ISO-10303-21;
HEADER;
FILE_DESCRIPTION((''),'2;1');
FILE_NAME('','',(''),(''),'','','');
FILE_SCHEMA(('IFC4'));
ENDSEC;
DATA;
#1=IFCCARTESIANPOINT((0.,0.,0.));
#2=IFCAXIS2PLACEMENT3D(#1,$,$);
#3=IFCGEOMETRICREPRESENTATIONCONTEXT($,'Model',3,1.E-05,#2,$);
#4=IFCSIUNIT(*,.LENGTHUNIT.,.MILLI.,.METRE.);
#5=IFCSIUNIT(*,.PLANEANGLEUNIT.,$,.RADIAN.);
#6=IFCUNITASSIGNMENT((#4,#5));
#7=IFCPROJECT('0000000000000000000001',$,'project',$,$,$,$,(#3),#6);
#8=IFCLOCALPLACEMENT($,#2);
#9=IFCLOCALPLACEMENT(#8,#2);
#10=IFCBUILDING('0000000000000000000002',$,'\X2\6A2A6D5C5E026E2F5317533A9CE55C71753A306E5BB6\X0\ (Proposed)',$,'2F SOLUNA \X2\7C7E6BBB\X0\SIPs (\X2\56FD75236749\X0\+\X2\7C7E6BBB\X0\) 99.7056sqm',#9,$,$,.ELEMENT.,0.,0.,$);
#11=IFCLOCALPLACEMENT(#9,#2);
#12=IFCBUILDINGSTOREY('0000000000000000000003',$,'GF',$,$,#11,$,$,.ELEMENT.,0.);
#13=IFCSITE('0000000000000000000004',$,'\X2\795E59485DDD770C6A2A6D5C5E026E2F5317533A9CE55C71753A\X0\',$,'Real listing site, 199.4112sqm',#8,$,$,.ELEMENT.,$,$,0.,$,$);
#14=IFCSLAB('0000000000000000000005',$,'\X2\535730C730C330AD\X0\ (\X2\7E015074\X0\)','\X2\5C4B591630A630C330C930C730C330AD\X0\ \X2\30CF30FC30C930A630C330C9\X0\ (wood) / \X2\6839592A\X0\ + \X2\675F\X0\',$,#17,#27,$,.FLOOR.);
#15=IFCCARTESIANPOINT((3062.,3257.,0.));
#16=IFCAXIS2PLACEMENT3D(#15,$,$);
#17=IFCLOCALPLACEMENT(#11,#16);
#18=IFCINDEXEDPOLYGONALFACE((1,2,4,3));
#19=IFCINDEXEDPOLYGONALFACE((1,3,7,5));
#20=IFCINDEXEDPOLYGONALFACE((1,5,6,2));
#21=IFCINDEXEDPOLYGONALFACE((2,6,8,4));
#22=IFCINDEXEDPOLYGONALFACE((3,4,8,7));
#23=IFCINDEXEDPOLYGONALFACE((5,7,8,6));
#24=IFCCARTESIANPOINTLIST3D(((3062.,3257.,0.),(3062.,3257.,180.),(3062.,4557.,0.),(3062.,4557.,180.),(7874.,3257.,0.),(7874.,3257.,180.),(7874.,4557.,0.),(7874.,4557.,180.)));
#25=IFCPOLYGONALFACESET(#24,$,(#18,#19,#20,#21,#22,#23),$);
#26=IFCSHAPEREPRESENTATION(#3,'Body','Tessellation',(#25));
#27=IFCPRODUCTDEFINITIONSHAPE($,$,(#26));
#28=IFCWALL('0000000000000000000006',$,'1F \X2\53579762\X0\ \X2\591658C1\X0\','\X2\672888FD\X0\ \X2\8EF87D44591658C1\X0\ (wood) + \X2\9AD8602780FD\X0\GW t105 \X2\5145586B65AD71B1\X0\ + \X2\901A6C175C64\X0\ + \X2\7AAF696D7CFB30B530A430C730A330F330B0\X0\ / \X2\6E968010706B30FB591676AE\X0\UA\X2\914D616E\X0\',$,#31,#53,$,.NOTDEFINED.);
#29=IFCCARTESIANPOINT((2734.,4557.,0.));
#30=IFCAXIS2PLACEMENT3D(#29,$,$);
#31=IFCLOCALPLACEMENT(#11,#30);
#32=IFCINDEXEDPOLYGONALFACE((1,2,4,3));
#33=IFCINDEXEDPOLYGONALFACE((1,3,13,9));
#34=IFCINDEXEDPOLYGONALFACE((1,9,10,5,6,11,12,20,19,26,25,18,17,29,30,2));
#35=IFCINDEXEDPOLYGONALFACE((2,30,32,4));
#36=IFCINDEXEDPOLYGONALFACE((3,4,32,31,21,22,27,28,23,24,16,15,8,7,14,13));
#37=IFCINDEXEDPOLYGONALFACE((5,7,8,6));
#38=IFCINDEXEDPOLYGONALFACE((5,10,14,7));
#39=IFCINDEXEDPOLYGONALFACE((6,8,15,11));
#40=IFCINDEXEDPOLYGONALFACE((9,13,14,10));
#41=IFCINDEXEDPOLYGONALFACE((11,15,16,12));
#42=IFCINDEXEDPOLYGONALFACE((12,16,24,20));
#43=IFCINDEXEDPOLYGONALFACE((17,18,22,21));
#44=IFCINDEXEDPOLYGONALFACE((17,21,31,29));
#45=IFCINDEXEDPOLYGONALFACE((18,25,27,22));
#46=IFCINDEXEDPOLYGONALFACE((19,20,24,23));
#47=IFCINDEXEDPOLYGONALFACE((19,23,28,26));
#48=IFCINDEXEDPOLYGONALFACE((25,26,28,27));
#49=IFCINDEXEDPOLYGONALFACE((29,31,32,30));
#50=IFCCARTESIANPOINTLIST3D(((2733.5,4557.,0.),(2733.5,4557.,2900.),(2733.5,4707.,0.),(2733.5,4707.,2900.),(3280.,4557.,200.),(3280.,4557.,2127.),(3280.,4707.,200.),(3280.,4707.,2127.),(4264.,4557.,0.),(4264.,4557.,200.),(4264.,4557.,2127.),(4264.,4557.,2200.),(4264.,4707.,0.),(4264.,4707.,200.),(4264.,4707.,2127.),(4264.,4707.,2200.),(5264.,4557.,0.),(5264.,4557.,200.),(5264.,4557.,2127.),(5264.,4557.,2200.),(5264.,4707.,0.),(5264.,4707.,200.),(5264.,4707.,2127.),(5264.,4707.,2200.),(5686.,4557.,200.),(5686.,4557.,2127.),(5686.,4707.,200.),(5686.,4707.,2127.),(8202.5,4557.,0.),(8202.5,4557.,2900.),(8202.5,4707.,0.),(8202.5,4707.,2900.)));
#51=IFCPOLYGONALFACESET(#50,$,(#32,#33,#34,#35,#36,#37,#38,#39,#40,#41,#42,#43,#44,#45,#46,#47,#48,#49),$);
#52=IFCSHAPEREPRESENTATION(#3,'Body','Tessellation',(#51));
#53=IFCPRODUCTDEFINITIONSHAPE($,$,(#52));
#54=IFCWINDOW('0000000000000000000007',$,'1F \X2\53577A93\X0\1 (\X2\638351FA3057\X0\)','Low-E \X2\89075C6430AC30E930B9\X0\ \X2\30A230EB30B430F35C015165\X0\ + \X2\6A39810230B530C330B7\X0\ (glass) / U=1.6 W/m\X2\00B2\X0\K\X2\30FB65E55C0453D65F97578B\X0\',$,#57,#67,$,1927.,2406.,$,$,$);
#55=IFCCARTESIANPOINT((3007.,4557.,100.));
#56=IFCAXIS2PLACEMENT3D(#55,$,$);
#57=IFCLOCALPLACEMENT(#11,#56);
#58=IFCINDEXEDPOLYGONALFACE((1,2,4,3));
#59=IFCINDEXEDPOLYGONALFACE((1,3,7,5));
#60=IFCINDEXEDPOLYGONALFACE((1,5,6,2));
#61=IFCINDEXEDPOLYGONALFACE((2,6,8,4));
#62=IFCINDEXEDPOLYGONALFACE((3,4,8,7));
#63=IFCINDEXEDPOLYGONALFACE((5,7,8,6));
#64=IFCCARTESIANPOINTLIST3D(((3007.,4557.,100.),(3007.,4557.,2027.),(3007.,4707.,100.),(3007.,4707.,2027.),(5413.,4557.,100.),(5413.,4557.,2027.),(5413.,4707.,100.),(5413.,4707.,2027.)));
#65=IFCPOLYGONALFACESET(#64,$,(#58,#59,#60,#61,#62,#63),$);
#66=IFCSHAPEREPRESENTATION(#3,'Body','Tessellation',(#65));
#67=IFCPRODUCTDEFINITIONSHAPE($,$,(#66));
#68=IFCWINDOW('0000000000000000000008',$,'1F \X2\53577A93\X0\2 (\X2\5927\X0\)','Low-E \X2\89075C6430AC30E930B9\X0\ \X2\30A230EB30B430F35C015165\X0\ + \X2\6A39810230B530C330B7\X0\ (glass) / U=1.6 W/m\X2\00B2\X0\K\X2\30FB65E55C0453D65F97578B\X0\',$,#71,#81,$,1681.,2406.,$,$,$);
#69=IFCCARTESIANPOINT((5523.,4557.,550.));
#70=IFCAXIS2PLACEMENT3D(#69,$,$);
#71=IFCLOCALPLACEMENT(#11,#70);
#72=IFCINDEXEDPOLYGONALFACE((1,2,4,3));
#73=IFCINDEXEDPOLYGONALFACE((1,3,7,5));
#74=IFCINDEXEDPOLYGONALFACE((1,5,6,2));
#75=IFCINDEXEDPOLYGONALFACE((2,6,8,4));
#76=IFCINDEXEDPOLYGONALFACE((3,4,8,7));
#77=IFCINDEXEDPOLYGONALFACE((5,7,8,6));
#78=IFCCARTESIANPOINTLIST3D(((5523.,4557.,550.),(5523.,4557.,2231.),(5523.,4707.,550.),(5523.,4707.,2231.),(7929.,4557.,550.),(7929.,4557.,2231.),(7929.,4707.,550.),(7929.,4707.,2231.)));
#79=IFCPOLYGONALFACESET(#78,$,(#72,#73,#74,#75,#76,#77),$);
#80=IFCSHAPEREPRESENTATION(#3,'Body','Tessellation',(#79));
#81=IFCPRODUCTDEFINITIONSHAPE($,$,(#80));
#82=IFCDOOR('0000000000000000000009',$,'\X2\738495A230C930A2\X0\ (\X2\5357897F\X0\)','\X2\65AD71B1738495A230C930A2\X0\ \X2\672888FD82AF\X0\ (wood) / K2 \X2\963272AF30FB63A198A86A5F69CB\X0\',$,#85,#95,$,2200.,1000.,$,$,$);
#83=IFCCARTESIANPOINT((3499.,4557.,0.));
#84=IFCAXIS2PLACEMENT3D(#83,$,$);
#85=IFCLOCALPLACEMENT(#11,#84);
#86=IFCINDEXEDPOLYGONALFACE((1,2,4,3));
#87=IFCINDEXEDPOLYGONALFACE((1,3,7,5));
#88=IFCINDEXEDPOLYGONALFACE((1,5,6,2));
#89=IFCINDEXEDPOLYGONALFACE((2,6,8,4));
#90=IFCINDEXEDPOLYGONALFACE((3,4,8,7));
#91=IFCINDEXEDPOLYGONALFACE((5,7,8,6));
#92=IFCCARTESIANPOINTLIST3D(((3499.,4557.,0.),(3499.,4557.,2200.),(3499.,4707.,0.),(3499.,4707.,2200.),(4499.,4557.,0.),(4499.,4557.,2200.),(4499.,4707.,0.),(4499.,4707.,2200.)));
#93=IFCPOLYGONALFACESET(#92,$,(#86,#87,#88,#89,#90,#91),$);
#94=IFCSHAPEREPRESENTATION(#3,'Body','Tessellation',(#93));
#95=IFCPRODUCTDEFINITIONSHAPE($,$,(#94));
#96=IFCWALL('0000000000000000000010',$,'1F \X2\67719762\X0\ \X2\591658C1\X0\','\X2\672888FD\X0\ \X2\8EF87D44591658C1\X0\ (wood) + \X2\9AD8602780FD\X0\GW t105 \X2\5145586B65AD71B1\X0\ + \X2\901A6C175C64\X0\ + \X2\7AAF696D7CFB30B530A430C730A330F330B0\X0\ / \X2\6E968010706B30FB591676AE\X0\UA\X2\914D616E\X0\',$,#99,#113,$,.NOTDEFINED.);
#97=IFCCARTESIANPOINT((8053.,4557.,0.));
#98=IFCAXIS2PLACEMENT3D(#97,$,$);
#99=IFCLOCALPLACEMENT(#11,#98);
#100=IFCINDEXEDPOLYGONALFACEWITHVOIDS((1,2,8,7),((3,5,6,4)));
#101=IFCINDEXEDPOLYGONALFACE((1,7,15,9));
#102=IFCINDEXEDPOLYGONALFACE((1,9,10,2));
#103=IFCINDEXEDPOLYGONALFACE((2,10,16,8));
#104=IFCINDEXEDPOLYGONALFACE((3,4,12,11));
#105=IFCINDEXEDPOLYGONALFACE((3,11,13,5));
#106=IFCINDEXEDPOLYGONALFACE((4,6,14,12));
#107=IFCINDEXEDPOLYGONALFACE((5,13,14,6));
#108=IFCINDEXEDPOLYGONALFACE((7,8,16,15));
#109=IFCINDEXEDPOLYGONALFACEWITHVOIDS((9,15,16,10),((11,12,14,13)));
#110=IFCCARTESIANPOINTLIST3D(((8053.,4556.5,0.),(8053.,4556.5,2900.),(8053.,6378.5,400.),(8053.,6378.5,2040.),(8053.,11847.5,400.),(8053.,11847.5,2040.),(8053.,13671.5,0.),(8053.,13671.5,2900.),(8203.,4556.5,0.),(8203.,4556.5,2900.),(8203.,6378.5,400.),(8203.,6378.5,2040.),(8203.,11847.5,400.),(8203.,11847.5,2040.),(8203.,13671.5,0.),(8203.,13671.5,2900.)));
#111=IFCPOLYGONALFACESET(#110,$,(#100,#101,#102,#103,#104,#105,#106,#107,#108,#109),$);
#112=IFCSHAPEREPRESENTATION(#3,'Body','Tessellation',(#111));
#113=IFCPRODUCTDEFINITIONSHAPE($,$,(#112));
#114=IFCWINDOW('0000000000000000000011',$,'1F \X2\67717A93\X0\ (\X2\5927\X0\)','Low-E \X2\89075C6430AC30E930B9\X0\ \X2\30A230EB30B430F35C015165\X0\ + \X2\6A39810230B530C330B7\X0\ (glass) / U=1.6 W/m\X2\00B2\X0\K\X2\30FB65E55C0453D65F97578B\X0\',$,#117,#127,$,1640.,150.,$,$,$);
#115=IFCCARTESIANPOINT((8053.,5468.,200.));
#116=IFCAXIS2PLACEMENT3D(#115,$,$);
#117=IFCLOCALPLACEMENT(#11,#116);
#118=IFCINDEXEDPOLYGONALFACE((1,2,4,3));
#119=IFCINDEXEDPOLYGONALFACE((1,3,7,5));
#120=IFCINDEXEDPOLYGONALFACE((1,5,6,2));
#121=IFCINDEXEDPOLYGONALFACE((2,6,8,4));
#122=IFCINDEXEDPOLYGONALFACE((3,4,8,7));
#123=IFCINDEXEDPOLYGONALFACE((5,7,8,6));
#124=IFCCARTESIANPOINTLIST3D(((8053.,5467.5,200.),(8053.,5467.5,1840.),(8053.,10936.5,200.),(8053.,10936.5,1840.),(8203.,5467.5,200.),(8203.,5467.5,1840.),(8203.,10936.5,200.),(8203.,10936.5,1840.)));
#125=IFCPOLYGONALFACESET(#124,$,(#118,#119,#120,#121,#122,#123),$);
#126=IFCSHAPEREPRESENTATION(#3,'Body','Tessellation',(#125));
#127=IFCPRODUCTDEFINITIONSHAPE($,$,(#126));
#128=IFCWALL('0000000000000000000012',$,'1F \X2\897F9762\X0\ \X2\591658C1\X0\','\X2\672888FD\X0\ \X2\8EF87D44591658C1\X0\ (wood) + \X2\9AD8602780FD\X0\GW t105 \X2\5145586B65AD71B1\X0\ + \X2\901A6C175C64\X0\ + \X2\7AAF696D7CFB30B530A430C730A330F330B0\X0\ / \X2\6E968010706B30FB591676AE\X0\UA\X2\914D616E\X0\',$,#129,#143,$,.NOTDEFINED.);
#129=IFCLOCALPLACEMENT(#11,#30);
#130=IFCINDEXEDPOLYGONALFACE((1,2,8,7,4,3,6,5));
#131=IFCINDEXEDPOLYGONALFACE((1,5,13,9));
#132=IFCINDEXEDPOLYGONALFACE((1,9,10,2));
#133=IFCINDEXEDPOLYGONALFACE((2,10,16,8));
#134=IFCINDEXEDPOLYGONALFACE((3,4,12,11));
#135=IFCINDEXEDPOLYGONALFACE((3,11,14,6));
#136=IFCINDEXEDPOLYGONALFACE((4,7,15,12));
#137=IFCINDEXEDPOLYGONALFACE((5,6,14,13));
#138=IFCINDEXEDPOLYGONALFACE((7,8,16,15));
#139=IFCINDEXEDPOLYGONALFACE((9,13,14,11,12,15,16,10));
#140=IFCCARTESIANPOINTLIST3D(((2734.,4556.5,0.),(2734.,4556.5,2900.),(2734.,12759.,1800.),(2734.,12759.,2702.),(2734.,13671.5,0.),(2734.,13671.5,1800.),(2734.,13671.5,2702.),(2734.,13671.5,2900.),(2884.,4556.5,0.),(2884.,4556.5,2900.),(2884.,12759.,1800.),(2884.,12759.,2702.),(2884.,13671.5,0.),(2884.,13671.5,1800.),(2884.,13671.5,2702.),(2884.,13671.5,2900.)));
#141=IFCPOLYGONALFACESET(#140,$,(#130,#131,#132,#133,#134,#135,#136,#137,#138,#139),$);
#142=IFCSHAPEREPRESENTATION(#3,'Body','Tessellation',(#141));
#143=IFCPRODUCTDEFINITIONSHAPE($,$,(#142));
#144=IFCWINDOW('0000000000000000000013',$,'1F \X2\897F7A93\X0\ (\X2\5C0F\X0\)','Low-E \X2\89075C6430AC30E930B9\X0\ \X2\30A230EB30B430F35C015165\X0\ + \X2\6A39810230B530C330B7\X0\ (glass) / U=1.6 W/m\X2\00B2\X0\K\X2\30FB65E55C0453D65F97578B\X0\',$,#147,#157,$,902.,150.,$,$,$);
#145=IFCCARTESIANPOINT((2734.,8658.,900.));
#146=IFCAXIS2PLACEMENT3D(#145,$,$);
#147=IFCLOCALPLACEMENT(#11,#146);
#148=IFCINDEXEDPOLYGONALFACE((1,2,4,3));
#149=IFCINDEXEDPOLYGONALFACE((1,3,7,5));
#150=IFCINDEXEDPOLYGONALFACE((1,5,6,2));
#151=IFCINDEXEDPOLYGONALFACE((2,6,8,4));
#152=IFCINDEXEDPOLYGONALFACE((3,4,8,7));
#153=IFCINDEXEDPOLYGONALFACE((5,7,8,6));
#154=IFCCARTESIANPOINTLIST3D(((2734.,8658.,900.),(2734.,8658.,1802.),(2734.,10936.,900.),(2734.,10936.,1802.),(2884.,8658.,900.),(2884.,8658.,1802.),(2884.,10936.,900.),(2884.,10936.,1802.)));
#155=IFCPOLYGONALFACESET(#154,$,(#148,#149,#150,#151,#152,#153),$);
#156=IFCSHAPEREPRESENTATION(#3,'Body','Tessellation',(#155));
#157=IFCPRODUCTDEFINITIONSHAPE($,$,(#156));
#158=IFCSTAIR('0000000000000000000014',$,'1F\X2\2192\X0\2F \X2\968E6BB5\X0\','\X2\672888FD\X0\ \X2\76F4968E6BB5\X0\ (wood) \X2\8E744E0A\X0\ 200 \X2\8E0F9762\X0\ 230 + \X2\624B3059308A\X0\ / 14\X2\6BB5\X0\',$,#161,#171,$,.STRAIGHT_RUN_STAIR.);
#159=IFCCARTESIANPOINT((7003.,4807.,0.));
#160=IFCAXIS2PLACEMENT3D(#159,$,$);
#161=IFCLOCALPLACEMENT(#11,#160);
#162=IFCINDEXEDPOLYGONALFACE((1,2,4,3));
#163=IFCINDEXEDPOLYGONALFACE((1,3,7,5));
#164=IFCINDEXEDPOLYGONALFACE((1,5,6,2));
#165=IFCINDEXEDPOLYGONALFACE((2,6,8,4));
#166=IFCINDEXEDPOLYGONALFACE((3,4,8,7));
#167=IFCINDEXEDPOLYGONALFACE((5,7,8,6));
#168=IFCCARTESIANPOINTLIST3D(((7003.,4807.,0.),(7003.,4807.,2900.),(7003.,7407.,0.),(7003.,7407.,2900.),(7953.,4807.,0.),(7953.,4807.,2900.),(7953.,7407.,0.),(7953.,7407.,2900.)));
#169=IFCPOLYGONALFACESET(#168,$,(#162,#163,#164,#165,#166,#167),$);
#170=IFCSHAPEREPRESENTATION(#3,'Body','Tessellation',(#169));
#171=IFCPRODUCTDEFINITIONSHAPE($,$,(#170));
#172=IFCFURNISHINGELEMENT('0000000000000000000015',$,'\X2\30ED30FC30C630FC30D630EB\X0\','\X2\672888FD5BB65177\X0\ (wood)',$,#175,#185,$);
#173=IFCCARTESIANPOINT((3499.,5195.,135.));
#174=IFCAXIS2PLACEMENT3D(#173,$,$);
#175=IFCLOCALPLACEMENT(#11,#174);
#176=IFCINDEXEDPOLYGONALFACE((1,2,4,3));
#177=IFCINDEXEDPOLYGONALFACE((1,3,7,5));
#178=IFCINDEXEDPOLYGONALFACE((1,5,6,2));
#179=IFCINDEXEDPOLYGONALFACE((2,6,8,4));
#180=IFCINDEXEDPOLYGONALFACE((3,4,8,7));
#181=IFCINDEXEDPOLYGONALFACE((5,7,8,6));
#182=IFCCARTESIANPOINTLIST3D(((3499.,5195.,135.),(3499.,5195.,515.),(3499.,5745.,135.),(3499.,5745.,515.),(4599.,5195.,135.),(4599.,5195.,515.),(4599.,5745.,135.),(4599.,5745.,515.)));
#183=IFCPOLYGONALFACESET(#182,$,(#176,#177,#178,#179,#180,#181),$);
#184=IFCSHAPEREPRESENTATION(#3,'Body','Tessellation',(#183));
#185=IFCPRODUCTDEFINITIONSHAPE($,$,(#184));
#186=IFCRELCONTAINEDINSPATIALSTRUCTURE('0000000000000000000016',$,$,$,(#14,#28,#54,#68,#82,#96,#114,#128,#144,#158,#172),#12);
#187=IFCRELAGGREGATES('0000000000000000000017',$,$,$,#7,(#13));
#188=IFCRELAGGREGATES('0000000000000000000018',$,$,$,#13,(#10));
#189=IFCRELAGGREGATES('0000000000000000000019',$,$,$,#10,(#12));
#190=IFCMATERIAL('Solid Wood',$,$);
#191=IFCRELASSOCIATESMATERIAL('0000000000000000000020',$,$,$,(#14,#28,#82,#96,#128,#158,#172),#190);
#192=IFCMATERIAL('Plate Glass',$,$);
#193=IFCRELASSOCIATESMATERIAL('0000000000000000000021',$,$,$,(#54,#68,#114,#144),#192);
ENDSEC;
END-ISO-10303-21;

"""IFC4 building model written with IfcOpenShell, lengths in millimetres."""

from ifc_helpers import new_model, si_unit, frame, frame_2d, origin, place, context, project, spatial, rectangle, extrude, material, element, fill, save


model = new_model("IFC4")

# Units and contexts
model_context = context("Model", 3, precision=1e-05, world=origin())
ifc_project = project(units=[si_unit("LENGTHUNIT", "METRE", prefix="MILLI"), si_unit("PLANEANGLEUNIT", "RADIAN")], contexts=[model_context])

# Site, building, storey
site_placement = place(None, origin())
site = spatial("IfcSite", under=ifc_project, at=site_placement, Name="神奈川県横浜市港北区鳥山町", ObjectType="Real listing site, 199.4112sqm", CompositionType="ELEMENT", RefElevation=0.0)
building_placement = place(site_placement, origin())
building = spatial("IfcBuilding", under=site, at=building_placement, Name="横浜市港北区鳥山町の家 (Proposed)", ObjectType="2F SOLUNA 籾殻SIPs (国産杉+籾殻) 99.7056sqm", CompositionType="ELEMENT", ElevationOfRefHeight=0.0, ElevationOfTerrain=0.0)
storey_placement = place(building_placement, origin())
storey = spatial("IfcBuildingStorey", under=building, at=storey_placement, Name="GF", CompositionType="ELEMENT", Elevation=0.0)

# Slab
ifc_material_1 = material(Name="Solid Wood")
slab_1_placement = place(storey_placement, frame((3062.0, 3257.0, 0.0)))
element("IfcSlab", 1, at=slab_1_placement, inside=storey, material=ifc_material_1, Name="南デッキ (縁側)", Description="屋外ウッドデッキ ハードウッド (wood) / 根太 + 束", PredefinedType="FLOOR", context=model_context, shape_type="SweptSolid", body=[
    extrude(rectangle(XDim=4812.0, YDim=1300.0, at=frame_2d((2406.0, 650.0))), frame((3062.0, 3257.0, 0.0)), (0.0, 0.0, 1.0), 180.0),
])

# Wall, openings, windows, door
wall_1_placement = place(storey_placement, frame((2734.0, 4557.0, 0.0)))
wall_1 = element("IfcWall", 2, at=wall_1_placement, inside=storey, material=ifc_material_1, Name="1F 南面 外壁", Description="木製 軸組外壁 (wood) + 高性能GW t105 充填断熱 + 通気層 + 窯業系サイディング / 準耐火・外皮UA配慮", PredefinedType="NOTDEFINED", context=model_context, shape_type="SweptSolid", body=[
    extrude(rectangle(XDim=5469.0, YDim=150.0, at=frame_2d((2734.0, 75.0))), frame((2734.0, 4557.0, 0.0)), (0.0, 0.0, 1.0), 2900.0),
])
opening_1_placement = place(storey_placement, frame((3007.0, 4557.0, 100.0)))
opening_1 = element("IfcOpeningElement", 3, at=opening_1_placement, cuts=wall_1, PredefinedType="NOTDEFINED", context=model_context, shape_type="SweptSolid", body=[
    extrude(rectangle(XDim=2406.0, YDim=150.0, at=frame_2d((1203.0, 75.0))), frame((3007.0, 4557.0, 100.0)), (0.0, 0.0, 1.0), 1927.0),
])
opening_2_placement = place(storey_placement, frame((5523.0, 4557.0, 550.0)))
opening_2 = element("IfcOpeningElement", 4, at=opening_2_placement, cuts=wall_1, PredefinedType="NOTDEFINED", context=model_context, shape_type="SweptSolid", body=[
    extrude(rectangle(XDim=2406.0, YDim=150.0, at=frame_2d((1203.0, 75.0))), frame((5523.0, 4557.0, 550.0)), (0.0, 0.0, 1.0), 1681.0),
])
opening_3_placement = place(storey_placement, frame((3499.0, 4557.0, 0.0)))
opening_3 = element("IfcOpeningElement", 5, at=opening_3_placement, cuts=wall_1, PredefinedType="NOTDEFINED", context=model_context, shape_type="SweptSolid", body=[
    extrude(rectangle(XDim=1000.0, YDim=150.0, at=frame_2d((500.0, 75.0))), frame((3499.0, 4557.0, 0.0)), (0.0, 0.0, 1.0), 2200.0),
])
ifc_material_2 = material(Name="Plate Glass")
window_1_placement = place(storey_placement, frame((3007.0, 4557.0, 100.0)))
window_1 = element("IfcWindow", 6, at=window_1_placement, inside=storey, material=ifc_material_2, Name="1F 南窓1 (掃出し)", Description="Low-E 複層ガラス アルゴン封入 + 樹脂サッシ (glass) / U=1.6 W/m²K・日射取得型", OverallHeight=1927.0, OverallWidth=2406.0, context=model_context, shape_type="SweptSolid", body=[
    extrude(rectangle(XDim=2406.0, YDim=150.0, at=frame_2d((1203.0, 75.0))), frame((3007.0, 4557.0, 100.0)), (0.0, 0.0, 1.0), 1927.0),
])
fill(opening_1, window_1)
window_2_placement = place(storey_placement, frame((5523.0, 4557.0, 550.0)))
window_2 = element("IfcWindow", 7, at=window_2_placement, inside=storey, material=ifc_material_2, Name="1F 南窓2 (大)", Description="Low-E 複層ガラス アルゴン封入 + 樹脂サッシ (glass) / U=1.6 W/m²K・日射取得型", OverallHeight=1681.0, OverallWidth=2406.0, context=model_context, shape_type="SweptSolid", body=[
    extrude(rectangle(XDim=2406.0, YDim=150.0, at=frame_2d((1203.0, 75.0))), frame((5523.0, 4557.0, 550.0)), (0.0, 0.0, 1.0), 1681.0),
])
fill(opening_2, window_2)
door_placement = place(storey_placement, frame((3499.0, 4557.0, 0.0)))
door = element("IfcDoor", 8, at=door_placement, inside=storey, material=ifc_material_1, Name="玄関ドア (南西)", Description="断熱玄関ドア 木製芯 (wood) / K2 防犯・採風機構", OverallHeight=2200.0, OverallWidth=1000.0, context=model_context, shape_type="SweptSolid", body=[
    extrude(rectangle(XDim=1000.0, YDim=150.0, at=frame_2d((500.0, 75.0))), frame((3499.0, 4557.0, 0.0)), (0.0, 0.0, 1.0), 2200.0),
])
fill(opening_3, door)

# Walls, openings, windows
wall_2_placement = place(storey_placement, frame((8053.0, 4557.0, 0.0)))
wall_2 = element("IfcWall", 9, at=wall_2_placement, inside=storey, material=ifc_material_1, Name="1F 東面 外壁", Description="木製 軸組外壁 (wood) + 高性能GW t105 充填断熱 + 通気層 + 窯業系サイディング / 準耐火・外皮UA配慮", PredefinedType="NOTDEFINED", context=model_context, shape_type="SweptSolid", body=[
    extrude(rectangle(XDim=150.0, YDim=9115.0, at=frame_2d((75.0, 4557.0))), frame((8053.0, 4557.0, 0.0)), (0.0, 0.0, 1.0), 2900.0),
])
opening_4_placement = place(storey_placement, frame((8053.0, 5468.0, 200.0)))
opening_4 = element("IfcOpeningElement", 10, at=opening_4_placement, cuts=wall_2, PredefinedType="NOTDEFINED", context=model_context, shape_type="SweptSolid", body=[
    extrude(rectangle(XDim=150.0, YDim=5469.0, at=frame_2d((75.0, 2734.0))), frame((8053.0, 5468.0, 200.0)), (0.0, 0.0, 1.0), 1640.0),
])
window_3_placement = place(storey_placement, frame((8053.0, 5468.0, 200.0)))
window_3 = element("IfcWindow", 11, at=window_3_placement, inside=storey, material=ifc_material_2, Name="1F 東窓 (大)", Description="Low-E 複層ガラス アルゴン封入 + 樹脂サッシ (glass) / U=1.6 W/m²K・日射取得型", OverallHeight=1640.0, OverallWidth=150.0, context=model_context, shape_type="SweptSolid", body=[
    extrude(rectangle(XDim=150.0, YDim=5469.0, at=frame_2d((75.0, 2734.0))), frame((8053.0, 5468.0, 200.0)), (0.0, 0.0, 1.0), 1640.0),
])
fill(opening_4, window_3)
wall_3_placement = place(storey_placement, frame((2734.0, 4557.0, 0.0)))
wall_3 = element("IfcWall", 12, at=wall_3_placement, inside=storey, material=ifc_material_1, Name="1F 西面 外壁", Description="木製 軸組外壁 (wood) + 高性能GW t105 充填断熱 + 通気層 + 窯業系サイディング / 準耐火・外皮UA配慮", PredefinedType="NOTDEFINED", context=model_context, shape_type="SweptSolid", body=[
    extrude(rectangle(XDim=150.0, YDim=9115.0, at=frame_2d((75.0, 4557.0))), frame((2734.0, 4557.0, 0.0)), (0.0, 0.0, 1.0), 2900.0),
])
opening_5_placement = place(storey_placement, frame((2734.0, 8658.0, 900.0)))
opening_5 = element("IfcOpeningElement", 13, at=opening_5_placement, cuts=wall_3, PredefinedType="NOTDEFINED", context=model_context, shape_type="SweptSolid", body=[
    extrude(rectangle(XDim=150.0, YDim=2278.0, at=frame_2d((75.0, 1139.0))), frame((2734.0, 8658.0, 900.0)), (0.0, 0.0, 1.0), 902.0),
])
window_4_placement = place(storey_placement, frame((2734.0, 8658.0, 900.0)))
window_4 = element("IfcWindow", 14, at=window_4_placement, inside=storey, material=ifc_material_2, Name="1F 西窓 (小)", Description="Low-E 複層ガラス アルゴン封入 + 樹脂サッシ (glass) / U=1.6 W/m²K・日射取得型", OverallHeight=902.0, OverallWidth=150.0, context=model_context, shape_type="SweptSolid", body=[
    extrude(rectangle(XDim=150.0, YDim=2278.0, at=frame_2d((75.0, 1139.0))), frame((2734.0, 8658.0, 900.0)), (0.0, 0.0, 1.0), 902.0),
])
fill(opening_5, window_4)

# Stair
stair_placement = place(storey_placement, frame((7003.0, 4807.0, 0.0)))
element("IfcStair", 15, at=stair_placement, inside=storey, material=ifc_material_1, Name="1F→2F 階段", Description="木製 直階段 (wood) 蹴上 200 踏面 230 + 手すり / 14段", PredefinedType="STRAIGHT_RUN_STAIR", context=model_context, shape_type="SweptSolid", body=[
    extrude(rectangle(XDim=950.0, YDim=2600.0, at=frame_2d((475.0, 1300.0))), frame((7003.0, 4807.0, 0.0)), (0.0, 0.0, 1.0), 2900.0),
])

# Furnishing element
furnishing_1_placement = place(storey_placement, frame((3499.0, 5195.0, 135.0)))
element("IfcFurnishingElement", 16, at=furnishing_1_placement, inside=storey, material=ifc_material_1, Name="ローテーブル", Description="木製家具 (wood)", context=model_context, shape_type="SweptSolid", body=[
    extrude(rectangle(XDim=1100.0, YDim=550.0, at=frame_2d((550.0, 275.0))), frame((3499.0, 5195.0, 135.0)), (0.0, 0.0, 1.0), 380.0),
])

save(model, "model.ifc")
